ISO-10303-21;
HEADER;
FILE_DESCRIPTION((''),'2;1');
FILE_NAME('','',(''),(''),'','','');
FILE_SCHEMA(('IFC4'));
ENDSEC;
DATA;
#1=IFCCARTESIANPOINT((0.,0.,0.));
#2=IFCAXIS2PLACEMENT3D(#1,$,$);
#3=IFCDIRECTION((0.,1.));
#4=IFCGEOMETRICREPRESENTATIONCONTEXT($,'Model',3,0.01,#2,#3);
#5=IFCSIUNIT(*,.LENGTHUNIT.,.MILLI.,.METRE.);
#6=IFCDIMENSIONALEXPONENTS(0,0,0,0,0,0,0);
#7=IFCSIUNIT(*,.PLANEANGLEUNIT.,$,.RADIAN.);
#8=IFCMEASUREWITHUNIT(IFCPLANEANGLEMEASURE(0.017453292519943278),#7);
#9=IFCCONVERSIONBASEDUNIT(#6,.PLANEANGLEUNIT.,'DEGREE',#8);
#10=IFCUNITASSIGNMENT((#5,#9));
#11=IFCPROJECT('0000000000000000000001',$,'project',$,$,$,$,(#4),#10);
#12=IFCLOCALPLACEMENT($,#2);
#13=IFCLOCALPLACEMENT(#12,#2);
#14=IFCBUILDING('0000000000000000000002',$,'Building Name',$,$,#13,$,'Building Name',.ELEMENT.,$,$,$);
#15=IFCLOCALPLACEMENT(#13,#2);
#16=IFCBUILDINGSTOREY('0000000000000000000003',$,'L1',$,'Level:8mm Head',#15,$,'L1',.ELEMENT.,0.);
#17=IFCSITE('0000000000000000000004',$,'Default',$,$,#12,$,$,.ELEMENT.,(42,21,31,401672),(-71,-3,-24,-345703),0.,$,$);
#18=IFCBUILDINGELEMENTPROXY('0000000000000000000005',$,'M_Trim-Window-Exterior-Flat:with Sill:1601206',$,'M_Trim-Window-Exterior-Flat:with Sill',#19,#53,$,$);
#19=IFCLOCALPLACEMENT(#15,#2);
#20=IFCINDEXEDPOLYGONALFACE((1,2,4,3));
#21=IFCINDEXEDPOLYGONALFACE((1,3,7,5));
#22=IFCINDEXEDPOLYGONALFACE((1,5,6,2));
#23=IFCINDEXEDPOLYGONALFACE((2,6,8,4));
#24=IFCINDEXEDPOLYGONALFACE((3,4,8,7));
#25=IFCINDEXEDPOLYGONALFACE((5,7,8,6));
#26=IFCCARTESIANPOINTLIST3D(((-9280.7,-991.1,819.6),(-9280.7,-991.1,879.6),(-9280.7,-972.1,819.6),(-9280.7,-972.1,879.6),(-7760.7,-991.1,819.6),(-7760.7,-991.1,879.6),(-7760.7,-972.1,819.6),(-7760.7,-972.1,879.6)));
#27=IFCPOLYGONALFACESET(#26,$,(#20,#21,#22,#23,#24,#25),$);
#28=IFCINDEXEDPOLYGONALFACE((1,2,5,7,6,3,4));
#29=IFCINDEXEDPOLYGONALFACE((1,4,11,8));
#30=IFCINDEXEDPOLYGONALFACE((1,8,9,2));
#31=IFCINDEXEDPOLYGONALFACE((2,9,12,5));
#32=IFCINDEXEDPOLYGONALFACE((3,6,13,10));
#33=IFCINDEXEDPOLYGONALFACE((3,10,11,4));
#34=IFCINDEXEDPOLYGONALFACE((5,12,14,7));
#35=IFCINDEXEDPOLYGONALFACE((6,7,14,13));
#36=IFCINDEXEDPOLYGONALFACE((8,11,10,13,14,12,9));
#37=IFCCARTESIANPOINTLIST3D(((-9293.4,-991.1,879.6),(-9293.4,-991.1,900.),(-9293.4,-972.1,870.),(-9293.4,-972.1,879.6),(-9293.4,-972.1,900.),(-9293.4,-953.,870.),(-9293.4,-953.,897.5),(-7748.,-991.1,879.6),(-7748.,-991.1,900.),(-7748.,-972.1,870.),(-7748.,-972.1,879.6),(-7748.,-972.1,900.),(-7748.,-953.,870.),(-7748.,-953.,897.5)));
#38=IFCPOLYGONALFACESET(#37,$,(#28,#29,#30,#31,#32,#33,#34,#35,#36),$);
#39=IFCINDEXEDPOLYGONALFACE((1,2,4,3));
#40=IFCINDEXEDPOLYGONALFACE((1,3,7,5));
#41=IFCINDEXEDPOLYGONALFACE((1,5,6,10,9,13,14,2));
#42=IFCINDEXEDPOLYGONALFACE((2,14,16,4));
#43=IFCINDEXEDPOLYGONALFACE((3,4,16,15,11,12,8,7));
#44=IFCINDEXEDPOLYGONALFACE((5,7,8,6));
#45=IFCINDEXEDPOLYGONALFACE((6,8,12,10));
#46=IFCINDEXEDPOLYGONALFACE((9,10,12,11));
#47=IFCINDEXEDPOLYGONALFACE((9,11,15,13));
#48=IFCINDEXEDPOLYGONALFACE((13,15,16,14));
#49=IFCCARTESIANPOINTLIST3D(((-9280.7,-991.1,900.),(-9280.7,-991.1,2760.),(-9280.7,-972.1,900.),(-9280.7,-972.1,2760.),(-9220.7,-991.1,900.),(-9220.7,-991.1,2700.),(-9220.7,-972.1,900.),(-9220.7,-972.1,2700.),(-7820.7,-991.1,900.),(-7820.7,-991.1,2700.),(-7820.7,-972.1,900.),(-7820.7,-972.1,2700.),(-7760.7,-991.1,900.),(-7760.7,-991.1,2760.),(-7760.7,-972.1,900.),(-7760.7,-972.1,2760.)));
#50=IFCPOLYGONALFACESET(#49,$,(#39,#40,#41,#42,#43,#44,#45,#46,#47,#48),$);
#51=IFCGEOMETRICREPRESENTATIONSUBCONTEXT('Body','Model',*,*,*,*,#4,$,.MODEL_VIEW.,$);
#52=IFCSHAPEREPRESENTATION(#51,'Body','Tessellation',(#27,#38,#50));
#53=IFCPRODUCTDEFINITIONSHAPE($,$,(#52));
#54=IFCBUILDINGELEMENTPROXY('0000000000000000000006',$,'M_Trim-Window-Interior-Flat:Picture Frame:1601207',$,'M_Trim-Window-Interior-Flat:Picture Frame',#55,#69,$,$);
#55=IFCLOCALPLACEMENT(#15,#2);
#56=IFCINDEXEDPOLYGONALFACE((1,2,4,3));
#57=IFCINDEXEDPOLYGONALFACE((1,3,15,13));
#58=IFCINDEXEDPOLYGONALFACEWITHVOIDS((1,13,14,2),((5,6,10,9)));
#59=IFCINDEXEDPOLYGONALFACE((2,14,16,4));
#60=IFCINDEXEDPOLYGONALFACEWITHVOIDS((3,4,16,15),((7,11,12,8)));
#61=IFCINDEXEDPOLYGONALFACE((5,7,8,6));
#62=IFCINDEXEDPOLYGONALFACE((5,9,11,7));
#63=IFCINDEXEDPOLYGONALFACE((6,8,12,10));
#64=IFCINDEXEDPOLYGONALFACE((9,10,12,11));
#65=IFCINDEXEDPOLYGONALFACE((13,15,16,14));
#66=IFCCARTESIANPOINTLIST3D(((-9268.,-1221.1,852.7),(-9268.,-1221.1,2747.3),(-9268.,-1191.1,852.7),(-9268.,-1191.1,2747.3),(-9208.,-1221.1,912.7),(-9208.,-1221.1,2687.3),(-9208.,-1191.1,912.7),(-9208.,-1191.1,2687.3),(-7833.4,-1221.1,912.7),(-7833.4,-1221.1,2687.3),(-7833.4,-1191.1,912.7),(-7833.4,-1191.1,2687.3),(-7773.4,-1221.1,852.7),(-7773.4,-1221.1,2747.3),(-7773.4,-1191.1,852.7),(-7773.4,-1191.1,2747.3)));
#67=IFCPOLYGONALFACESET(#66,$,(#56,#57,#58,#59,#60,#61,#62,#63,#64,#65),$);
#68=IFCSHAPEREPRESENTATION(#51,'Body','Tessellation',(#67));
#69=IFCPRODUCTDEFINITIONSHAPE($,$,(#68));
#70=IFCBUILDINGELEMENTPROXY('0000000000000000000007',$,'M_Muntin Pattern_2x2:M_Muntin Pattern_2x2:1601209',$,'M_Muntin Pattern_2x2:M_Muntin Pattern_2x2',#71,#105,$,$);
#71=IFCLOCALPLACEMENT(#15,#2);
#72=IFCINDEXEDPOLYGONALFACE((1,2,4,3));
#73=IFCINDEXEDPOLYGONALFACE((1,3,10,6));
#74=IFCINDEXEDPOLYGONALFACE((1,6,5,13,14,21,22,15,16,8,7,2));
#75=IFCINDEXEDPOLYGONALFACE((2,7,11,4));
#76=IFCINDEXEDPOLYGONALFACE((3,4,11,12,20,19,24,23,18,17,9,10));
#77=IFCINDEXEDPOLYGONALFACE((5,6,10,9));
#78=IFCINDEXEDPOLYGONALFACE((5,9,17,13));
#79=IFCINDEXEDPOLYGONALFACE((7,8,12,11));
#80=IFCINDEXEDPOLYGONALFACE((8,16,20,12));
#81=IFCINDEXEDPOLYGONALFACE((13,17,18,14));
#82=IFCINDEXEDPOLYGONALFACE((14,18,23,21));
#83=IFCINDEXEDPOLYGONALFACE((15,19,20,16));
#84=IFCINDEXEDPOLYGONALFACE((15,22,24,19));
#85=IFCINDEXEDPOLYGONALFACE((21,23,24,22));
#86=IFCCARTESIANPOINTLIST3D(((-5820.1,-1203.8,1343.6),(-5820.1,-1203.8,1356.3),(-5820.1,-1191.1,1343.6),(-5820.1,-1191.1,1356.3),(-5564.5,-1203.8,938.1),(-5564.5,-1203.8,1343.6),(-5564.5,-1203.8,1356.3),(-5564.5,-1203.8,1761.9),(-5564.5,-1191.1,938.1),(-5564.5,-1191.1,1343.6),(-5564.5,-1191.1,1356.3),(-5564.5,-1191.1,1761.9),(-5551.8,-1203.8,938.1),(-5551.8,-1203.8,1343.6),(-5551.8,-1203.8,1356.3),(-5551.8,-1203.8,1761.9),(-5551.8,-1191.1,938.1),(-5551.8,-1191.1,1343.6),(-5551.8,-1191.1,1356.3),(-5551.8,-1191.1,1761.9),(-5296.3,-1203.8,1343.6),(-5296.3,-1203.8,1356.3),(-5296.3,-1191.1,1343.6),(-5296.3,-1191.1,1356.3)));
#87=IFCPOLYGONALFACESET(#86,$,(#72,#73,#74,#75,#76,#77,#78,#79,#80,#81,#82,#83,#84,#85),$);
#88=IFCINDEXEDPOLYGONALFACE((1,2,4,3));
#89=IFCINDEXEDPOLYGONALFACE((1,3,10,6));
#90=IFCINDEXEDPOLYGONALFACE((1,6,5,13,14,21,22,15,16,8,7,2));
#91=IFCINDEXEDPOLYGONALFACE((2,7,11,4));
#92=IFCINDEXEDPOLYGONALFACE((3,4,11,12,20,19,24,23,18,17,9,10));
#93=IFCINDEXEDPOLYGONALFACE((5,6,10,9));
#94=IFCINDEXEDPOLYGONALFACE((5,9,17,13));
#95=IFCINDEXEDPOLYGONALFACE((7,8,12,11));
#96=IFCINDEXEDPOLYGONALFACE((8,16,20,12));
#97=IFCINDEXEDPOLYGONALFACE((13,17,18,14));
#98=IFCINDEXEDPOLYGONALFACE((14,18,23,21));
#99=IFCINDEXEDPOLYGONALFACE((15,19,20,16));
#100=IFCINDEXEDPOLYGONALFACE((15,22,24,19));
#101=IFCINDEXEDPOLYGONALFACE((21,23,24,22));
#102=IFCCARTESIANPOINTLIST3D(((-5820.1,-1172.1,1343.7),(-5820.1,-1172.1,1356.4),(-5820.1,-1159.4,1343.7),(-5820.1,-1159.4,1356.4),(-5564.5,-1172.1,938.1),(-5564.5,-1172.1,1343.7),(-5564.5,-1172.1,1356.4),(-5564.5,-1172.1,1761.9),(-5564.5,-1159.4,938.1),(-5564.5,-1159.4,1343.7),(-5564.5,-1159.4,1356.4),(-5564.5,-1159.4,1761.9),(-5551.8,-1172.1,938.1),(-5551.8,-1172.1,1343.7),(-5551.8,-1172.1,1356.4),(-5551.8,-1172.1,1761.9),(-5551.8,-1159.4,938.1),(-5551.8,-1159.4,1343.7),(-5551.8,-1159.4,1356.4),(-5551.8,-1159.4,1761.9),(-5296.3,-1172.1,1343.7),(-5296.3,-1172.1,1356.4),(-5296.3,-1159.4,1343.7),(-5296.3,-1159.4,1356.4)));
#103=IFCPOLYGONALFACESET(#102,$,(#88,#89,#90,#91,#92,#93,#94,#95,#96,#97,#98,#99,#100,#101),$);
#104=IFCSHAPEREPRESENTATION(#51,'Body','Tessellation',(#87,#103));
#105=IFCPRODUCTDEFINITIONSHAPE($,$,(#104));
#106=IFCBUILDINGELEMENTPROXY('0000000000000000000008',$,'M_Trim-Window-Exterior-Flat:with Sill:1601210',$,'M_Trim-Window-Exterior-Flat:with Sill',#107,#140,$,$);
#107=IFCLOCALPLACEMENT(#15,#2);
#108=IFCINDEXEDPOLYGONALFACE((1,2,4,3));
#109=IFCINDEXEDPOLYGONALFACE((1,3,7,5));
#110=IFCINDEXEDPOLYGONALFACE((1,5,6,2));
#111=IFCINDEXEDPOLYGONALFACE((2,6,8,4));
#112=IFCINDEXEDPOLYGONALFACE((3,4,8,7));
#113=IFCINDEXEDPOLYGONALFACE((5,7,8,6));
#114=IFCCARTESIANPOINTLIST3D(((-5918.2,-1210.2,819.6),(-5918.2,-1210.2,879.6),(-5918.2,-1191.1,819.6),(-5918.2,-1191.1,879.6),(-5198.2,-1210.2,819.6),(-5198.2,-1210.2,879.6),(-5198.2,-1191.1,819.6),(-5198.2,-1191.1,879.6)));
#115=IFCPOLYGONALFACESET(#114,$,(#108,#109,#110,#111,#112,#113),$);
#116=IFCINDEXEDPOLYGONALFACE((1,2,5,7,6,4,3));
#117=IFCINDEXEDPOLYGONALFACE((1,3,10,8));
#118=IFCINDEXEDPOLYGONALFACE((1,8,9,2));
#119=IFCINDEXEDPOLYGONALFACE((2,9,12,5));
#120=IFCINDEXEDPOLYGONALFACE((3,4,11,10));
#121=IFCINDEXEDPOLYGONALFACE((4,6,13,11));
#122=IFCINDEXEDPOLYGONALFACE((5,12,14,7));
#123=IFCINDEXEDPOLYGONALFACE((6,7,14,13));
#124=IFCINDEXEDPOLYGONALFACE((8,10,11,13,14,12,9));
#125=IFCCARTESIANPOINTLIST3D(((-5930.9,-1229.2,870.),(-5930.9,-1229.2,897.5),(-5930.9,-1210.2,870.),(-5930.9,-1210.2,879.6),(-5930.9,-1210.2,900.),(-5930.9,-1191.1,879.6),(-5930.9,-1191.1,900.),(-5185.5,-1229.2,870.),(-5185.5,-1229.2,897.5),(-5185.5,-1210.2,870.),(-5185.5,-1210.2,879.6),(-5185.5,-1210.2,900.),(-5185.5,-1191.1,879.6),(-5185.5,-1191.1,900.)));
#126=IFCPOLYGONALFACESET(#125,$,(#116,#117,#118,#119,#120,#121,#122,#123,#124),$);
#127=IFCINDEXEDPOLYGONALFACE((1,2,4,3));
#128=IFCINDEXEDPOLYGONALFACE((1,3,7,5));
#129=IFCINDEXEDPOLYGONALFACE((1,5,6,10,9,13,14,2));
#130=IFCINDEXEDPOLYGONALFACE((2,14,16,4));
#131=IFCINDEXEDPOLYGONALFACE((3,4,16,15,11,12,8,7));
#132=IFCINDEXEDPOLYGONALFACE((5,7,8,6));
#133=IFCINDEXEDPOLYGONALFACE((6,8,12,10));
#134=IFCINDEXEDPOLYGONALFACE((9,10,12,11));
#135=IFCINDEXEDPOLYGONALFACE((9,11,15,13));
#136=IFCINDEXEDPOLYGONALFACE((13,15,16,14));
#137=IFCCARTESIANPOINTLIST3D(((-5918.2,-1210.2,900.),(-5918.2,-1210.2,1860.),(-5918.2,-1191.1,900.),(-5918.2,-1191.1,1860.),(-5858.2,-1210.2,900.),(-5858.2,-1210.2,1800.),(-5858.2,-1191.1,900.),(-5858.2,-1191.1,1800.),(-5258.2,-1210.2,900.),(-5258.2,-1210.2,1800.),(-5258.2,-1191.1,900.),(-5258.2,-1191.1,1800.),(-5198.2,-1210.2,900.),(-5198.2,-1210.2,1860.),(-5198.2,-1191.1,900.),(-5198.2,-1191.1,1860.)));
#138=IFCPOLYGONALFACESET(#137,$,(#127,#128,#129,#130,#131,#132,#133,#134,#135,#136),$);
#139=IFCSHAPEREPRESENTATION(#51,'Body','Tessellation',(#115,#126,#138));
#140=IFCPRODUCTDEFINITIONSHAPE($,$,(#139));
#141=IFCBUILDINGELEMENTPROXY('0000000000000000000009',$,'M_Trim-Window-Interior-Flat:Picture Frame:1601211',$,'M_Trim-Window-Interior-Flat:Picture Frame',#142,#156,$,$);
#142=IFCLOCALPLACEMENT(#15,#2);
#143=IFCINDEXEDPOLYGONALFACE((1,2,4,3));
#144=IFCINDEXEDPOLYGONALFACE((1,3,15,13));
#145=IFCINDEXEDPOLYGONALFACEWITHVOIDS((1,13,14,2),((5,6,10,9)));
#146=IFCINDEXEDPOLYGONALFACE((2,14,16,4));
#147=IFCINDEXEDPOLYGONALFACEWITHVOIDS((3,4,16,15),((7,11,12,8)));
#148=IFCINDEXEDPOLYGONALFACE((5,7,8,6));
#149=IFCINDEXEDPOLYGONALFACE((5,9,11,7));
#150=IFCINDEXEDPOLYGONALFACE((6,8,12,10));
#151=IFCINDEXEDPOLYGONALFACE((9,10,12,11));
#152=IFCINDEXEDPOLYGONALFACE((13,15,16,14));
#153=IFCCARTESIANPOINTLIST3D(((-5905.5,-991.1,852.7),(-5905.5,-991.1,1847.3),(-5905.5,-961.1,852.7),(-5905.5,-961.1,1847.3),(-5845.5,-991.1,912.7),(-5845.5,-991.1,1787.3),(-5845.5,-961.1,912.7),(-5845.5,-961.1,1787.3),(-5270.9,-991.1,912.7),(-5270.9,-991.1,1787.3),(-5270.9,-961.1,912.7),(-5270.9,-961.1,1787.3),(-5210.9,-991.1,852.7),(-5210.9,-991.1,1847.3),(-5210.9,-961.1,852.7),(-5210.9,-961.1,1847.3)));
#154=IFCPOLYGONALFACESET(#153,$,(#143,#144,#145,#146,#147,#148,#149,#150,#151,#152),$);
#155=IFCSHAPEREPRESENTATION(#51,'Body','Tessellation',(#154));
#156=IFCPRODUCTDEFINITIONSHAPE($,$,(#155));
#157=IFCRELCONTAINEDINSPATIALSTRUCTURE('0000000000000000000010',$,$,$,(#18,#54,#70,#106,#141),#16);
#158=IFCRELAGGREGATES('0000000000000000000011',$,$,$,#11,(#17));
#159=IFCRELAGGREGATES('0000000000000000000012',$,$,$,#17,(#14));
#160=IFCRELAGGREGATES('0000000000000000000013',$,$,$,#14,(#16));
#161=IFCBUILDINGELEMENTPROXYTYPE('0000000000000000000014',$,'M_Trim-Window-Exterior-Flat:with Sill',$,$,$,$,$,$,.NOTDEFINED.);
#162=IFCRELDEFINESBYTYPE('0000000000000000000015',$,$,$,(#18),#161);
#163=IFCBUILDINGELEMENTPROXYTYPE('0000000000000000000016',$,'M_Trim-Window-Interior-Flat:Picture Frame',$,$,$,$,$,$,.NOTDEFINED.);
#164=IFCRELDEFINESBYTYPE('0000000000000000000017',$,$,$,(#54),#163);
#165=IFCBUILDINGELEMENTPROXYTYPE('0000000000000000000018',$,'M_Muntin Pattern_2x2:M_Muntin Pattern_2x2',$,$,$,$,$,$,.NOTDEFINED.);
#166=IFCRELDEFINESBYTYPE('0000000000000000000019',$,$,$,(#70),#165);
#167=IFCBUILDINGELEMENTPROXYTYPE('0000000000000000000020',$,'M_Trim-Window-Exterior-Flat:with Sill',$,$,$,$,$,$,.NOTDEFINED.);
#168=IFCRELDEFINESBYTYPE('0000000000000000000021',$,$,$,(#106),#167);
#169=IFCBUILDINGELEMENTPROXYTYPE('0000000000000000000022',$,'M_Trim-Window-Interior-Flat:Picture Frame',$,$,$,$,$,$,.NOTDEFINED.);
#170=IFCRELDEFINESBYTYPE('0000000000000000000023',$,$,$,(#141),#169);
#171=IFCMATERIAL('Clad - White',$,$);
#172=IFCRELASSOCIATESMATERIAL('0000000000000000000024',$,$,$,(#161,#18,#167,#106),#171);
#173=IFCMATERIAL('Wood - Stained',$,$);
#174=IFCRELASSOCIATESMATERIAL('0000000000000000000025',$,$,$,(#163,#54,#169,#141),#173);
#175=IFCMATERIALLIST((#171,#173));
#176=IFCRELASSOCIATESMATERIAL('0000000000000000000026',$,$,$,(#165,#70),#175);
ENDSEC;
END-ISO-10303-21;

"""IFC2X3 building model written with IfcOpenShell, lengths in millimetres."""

from ifc_helpers import new_model, entity, si_unit, converted_unit, direction, frame, frame_2d, origin, place, context, subcontext, project, spatial, polyline, rectangle, outline, extrude, source, transform, mapped, material, material_list, type_object, type_shapes, element, save


model = new_model("IFC2X3")

# Units and contexts
model_context = context("Model", 3, precision=0.01, world=origin(), true_north=direction((0.0, 1.0)))
body_context = subcontext(model_context, "Body", "Model", "MODEL_VIEW")
ifc_project = project(units=[si_unit("LENGTHUNIT", "METRE", prefix="MILLI"), converted_unit("PLANEANGLEUNIT", "DEGREE", entity("IfcPlaneAngleMeasure", 0.017453292519943278), si_unit("PLANEANGLEUNIT", "RADIAN"), dimensions=[0, 0, 0, 0, 0, 0, 0])], contexts=[model_context])

# Site, building, storey
site_placement = place(None, origin())
site = spatial("IfcSite", under=ifc_project, at=site_placement, Name="Default", CompositionType="ELEMENT", RefLatitude=(42, 21, 31, 401672), RefLongitude=(-71, -3, -24, -345703), RefElevation=0.0)
building_placement = place(site_placement, origin())
building = spatial("IfcBuilding", under=site, at=building_placement, Name="Building Name", LongName="Building Name", CompositionType="ELEMENT")
storey_placement = place(building_placement, origin())
storey = spatial("IfcBuildingStorey", under=building, at=storey_placement, Name="L1", ObjectType="Level:8mm Head", LongName="L1", CompositionType="ELEMENT", Elevation=0.0)

# Building element proxies
ifc_material_1 = material(Name="Clad - White")
ifc_material_2 = material(Name="Wood - Stained")
ifc_material_list = material_list([ifc_material_1, ifc_material_2])
building_element_proxy_type_1 = type_object("IfcBuildingElementProxyType", Name="M_Trim-Window-Exterior-Flat:with Sill", PredefinedType="NOTDEFINED", material=ifc_material_1)
shared_shape_1 = source(origin(), body_context, "Body", "SweptSolid", [
    extrude(rectangle(XDim=60.0, YDim=1520.0, at=frame_2d((0.0, 0.0), x_axis=(1.0, 0.0))), frame((0.0, 1850.4, 0.0), z_axis=(0.0, 0.0, 1.0), x_axis=(0.0, 1.0, 0.0)), (0.0, 0.0, 1.0), 19.0),
    extrude(outline(polyline([(-15.2, -19.0), (12.3, -19.0), (14.8, 0.0), (14.8, 19.0), (-5.7, 19.0), (-5.7, 0.0), (-15.2, 0.0), (-15.2, -19.0)])), frame((-772.7, 1814.8, 19.0), z_axis=(1.0, 0.0, 0.0), x_axis=(0.0, -1.0, 0.0)), (0.0, 0.0, 1.0), 1545.4),
    extrude(outline(polyline([(-760.0, -945.0), (760.0, -945.0), (760.0, 915.0), (700.0, 915.0), (700.0, -885.0), (-700.0, -885.0), (-700.0, 915.0), (-760.0, 915.0), (-760.0, -945.0)])), frame((0.0, 885.0, 0.0)), (0.0, 0.0, 1.0), 19.0),
])
type_shapes(building_element_proxy_type_1, [shared_shape_1])
proxy_1_placement = place(storey_placement, frame((-8520.7, -991.1, 2700.0), z_axis=(0.0, 1.0, 0.0), x_axis=(1.0, 0.0, 0.0)))
element("IfcBuildingElementProxy", 1, at=proxy_1_placement, inside=storey, type_object=building_element_proxy_type_1, material=ifc_material_1, Name="M_Trim-Window-Exterior-Flat:with Sill:1601206", ObjectType="M_Trim-Window-Exterior-Flat:with Sill", context=body_context, shape_type="MappedRepresentation", body=[
    mapped(shared_shape_1, transform((0.0, 0.0, 0.0), scale=1.0)),
])
building_element_proxy_type_2 = type_object("IfcBuildingElementProxyType", Name="M_Trim-Window-Interior-Flat:Picture Frame", PredefinedType="NOTDEFINED", material=ifc_material_2)
shared_shape_2 = source(origin(), body_context, "Body", "SweptSolid", [
    extrude(outline(polyline([(-947.3, -747.3), (947.3, -747.3), (947.3, 747.3), (-947.3, 747.3), (-947.3, -747.3)]), holes=[polyline([(-887.3, -687.3), (-887.3, 687.3), (887.3, 687.3), (887.3, -687.3), (-887.3, -687.3)])]), frame((0.0, 900.0, 0.0), z_axis=(0.0, 0.0, 1.0), x_axis=(0.0, 1.0, 0.0)), (0.0, 0.0, 1.0), 30.0),
])
type_shapes(building_element_proxy_type_2, [shared_shape_2])
proxy_2_placement = place(storey_placement, frame((-8520.7, -1191.1, 2700.0), z_axis=(0.0, -1.0, 0.0), x_axis=(-1.0, 0.0, 0.0)))
element("IfcBuildingElementProxy", 2, at=proxy_2_placement, inside=storey, type_object=building_element_proxy_type_2, material=ifc_material_2, Name="M_Trim-Window-Interior-Flat:Picture Frame:1601207", ObjectType="M_Trim-Window-Interior-Flat:Picture Frame", context=body_context, shape_type="MappedRepresentation", body=[
    mapped(shared_shape_2, transform((0.0, 0.0, 0.0), scale=1.0)),
])
building_element_proxy_type_3 = type_object("IfcBuildingElementProxyType", Name="M_Muntin Pattern_2x2:M_Muntin Pattern_2x2", PredefinedType="NOTDEFINED", material=ifc_material_list)
shared_shape_3 = source(origin(), body_context, "Body", "SweptSolid", [
    extrude(outline(polyline([(6.4, -6.4), (411.9, -6.4), (411.9, 6.3), (6.4, 6.3), (6.4, 261.9), (-6.3, 261.9), (-6.3, 6.3), (-411.9, 6.3), (-411.9, -6.4), (-6.3, -6.4), (-6.3, -261.9), (6.4, -261.9), (6.4, -6.4)])), frame((0.0, 9.5, 411.9), z_axis=(0.0, 1.0, 0.0), x_axis=(0.0, 0.0, 1.0)), (0.0, 0.0, 1.0), 12.7),
    extrude(outline(polyline([(6.4, -6.4), (411.9, -6.4), (411.9, 6.3), (6.4, 6.3), (6.4, 261.9), (-6.3, 261.9), (-6.3, 6.3), (-411.9, 6.3), (-411.9, -6.4), (-6.3, -6.4), (-6.3, -261.9), (6.4, -261.9), (6.4, -6.4)])), frame((0.0, -22.2, 411.9), z_axis=(0.0, 1.0, 0.0), x_axis=(0.0, 0.0, 1.0)), (0.0, 0.0, 1.0), 12.7),
])
type_shapes(building_element_proxy_type_3, [shared_shape_3])
proxy_3_placement = place(storey_placement, frame((-5558.2, -1181.6, 938.1), z_axis=(0.0, 0.0, 1.0), x_axis=(-1.0, 0.0, 0.0)))
element("IfcBuildingElementProxy", 3, at=proxy_3_placement, inside=storey, type_object=building_element_proxy_type_3, material=ifc_material_list, Name="M_Muntin Pattern_2x2:M_Muntin Pattern_2x2:1601209", ObjectType="M_Muntin Pattern_2x2:M_Muntin Pattern_2x2", context=body_context, shape_type="MappedRepresentation", body=[
    mapped(shared_shape_3, transform((0.0, 0.0, 0.0), scale=1.0)),
])
building_element_proxy_type_4 = type_object("IfcBuildingElementProxyType", Name="M_Trim-Window-Exterior-Flat:with Sill", PredefinedType="NOTDEFINED", material=ifc_material_1)
shared_shape_4 = source(origin(), body_context, "Body", "SweptSolid", [
    extrude(rectangle(XDim=60.0, YDim=720.0, at=frame_2d((0.0, 0.0), x_axis=(1.0, 0.0))), frame((0.0, 950.4, 0.0), z_axis=(0.0, 0.0, 1.0), x_axis=(0.0, 1.0, 0.0)), (0.0, 0.0, 1.0), 19.0),
    extrude(outline(polyline([(-15.2, -19.0), (12.3, -19.0), (14.8, 0.0), (14.8, 19.0), (-5.7, 19.0), (-5.7, 0.0), (-15.2, 0.0), (-15.2, -19.0)])), frame((-372.7, 914.8, 19.0), z_axis=(1.0, 0.0, 0.0), x_axis=(0.0, -1.0, 0.0)), (0.0, 0.0, 1.0), 745.4),
    extrude(outline(polyline([(-360.0, -495.0), (360.0, -495.0), (360.0, 465.0), (300.0, 465.0), (300.0, -435.0), (-300.0, -435.0), (-300.0, 465.0), (-360.0, 465.0), (-360.0, -495.0)])), frame((0.0, 435.0, 0.0)), (0.0, 0.0, 1.0), 19.0),
])
type_shapes(building_element_proxy_type_4, [shared_shape_4])
proxy_4_placement = place(storey_placement, frame((-5558.2, -1191.1, 1800.0), z_axis=(0.0, -1.0, 0.0), x_axis=(-1.0, 0.0, 0.0)))
element("IfcBuildingElementProxy", 4, at=proxy_4_placement, inside=storey, type_object=building_element_proxy_type_4, material=ifc_material_1, Name="M_Trim-Window-Exterior-Flat:with Sill:1601210", ObjectType="M_Trim-Window-Exterior-Flat:with Sill", context=body_context, shape_type="MappedRepresentation", body=[
    mapped(shared_shape_4, transform((0.0, 0.0, 0.0), scale=1.0)),
])
building_element_proxy_type_5 = type_object("IfcBuildingElementProxyType", Name="M_Trim-Window-Interior-Flat:Picture Frame", PredefinedType="NOTDEFINED", material=ifc_material_2)
shared_shape_5 = source(origin(), body_context, "Body", "SweptSolid", [
    extrude(outline(polyline([(-497.3, -347.3), (497.3, -347.3), (497.3, 347.3), (-497.3, 347.3), (-497.3, -347.3)]), holes=[polyline([(-437.3, -287.3), (-437.3, 287.3), (437.3, 287.3), (437.3, -287.3), (-437.3, -287.3)])]), frame((0.0, 450.0, 0.0), z_axis=(0.0, 0.0, 1.0), x_axis=(0.0, 1.0, 0.0)), (0.0, 0.0, 1.0), 30.0),
])
type_shapes(building_element_proxy_type_5, [shared_shape_5])
proxy_5_placement = place(storey_placement, frame((-5558.2, -991.1, 1800.0), z_axis=(0.0, 1.0, 0.0), x_axis=(1.0, 0.0, 0.0)))
element("IfcBuildingElementProxy", 5, at=proxy_5_placement, inside=storey, type_object=building_element_proxy_type_5, material=ifc_material_2, Name="M_Trim-Window-Interior-Flat:Picture Frame:1601211", ObjectType="M_Trim-Window-Interior-Flat:Picture Frame", context=body_context, shape_type="MappedRepresentation", body=[
    mapped(shared_shape_5, transform((0.0, 0.0, 0.0), scale=1.0)),
])

save(model, "model.ifc")
